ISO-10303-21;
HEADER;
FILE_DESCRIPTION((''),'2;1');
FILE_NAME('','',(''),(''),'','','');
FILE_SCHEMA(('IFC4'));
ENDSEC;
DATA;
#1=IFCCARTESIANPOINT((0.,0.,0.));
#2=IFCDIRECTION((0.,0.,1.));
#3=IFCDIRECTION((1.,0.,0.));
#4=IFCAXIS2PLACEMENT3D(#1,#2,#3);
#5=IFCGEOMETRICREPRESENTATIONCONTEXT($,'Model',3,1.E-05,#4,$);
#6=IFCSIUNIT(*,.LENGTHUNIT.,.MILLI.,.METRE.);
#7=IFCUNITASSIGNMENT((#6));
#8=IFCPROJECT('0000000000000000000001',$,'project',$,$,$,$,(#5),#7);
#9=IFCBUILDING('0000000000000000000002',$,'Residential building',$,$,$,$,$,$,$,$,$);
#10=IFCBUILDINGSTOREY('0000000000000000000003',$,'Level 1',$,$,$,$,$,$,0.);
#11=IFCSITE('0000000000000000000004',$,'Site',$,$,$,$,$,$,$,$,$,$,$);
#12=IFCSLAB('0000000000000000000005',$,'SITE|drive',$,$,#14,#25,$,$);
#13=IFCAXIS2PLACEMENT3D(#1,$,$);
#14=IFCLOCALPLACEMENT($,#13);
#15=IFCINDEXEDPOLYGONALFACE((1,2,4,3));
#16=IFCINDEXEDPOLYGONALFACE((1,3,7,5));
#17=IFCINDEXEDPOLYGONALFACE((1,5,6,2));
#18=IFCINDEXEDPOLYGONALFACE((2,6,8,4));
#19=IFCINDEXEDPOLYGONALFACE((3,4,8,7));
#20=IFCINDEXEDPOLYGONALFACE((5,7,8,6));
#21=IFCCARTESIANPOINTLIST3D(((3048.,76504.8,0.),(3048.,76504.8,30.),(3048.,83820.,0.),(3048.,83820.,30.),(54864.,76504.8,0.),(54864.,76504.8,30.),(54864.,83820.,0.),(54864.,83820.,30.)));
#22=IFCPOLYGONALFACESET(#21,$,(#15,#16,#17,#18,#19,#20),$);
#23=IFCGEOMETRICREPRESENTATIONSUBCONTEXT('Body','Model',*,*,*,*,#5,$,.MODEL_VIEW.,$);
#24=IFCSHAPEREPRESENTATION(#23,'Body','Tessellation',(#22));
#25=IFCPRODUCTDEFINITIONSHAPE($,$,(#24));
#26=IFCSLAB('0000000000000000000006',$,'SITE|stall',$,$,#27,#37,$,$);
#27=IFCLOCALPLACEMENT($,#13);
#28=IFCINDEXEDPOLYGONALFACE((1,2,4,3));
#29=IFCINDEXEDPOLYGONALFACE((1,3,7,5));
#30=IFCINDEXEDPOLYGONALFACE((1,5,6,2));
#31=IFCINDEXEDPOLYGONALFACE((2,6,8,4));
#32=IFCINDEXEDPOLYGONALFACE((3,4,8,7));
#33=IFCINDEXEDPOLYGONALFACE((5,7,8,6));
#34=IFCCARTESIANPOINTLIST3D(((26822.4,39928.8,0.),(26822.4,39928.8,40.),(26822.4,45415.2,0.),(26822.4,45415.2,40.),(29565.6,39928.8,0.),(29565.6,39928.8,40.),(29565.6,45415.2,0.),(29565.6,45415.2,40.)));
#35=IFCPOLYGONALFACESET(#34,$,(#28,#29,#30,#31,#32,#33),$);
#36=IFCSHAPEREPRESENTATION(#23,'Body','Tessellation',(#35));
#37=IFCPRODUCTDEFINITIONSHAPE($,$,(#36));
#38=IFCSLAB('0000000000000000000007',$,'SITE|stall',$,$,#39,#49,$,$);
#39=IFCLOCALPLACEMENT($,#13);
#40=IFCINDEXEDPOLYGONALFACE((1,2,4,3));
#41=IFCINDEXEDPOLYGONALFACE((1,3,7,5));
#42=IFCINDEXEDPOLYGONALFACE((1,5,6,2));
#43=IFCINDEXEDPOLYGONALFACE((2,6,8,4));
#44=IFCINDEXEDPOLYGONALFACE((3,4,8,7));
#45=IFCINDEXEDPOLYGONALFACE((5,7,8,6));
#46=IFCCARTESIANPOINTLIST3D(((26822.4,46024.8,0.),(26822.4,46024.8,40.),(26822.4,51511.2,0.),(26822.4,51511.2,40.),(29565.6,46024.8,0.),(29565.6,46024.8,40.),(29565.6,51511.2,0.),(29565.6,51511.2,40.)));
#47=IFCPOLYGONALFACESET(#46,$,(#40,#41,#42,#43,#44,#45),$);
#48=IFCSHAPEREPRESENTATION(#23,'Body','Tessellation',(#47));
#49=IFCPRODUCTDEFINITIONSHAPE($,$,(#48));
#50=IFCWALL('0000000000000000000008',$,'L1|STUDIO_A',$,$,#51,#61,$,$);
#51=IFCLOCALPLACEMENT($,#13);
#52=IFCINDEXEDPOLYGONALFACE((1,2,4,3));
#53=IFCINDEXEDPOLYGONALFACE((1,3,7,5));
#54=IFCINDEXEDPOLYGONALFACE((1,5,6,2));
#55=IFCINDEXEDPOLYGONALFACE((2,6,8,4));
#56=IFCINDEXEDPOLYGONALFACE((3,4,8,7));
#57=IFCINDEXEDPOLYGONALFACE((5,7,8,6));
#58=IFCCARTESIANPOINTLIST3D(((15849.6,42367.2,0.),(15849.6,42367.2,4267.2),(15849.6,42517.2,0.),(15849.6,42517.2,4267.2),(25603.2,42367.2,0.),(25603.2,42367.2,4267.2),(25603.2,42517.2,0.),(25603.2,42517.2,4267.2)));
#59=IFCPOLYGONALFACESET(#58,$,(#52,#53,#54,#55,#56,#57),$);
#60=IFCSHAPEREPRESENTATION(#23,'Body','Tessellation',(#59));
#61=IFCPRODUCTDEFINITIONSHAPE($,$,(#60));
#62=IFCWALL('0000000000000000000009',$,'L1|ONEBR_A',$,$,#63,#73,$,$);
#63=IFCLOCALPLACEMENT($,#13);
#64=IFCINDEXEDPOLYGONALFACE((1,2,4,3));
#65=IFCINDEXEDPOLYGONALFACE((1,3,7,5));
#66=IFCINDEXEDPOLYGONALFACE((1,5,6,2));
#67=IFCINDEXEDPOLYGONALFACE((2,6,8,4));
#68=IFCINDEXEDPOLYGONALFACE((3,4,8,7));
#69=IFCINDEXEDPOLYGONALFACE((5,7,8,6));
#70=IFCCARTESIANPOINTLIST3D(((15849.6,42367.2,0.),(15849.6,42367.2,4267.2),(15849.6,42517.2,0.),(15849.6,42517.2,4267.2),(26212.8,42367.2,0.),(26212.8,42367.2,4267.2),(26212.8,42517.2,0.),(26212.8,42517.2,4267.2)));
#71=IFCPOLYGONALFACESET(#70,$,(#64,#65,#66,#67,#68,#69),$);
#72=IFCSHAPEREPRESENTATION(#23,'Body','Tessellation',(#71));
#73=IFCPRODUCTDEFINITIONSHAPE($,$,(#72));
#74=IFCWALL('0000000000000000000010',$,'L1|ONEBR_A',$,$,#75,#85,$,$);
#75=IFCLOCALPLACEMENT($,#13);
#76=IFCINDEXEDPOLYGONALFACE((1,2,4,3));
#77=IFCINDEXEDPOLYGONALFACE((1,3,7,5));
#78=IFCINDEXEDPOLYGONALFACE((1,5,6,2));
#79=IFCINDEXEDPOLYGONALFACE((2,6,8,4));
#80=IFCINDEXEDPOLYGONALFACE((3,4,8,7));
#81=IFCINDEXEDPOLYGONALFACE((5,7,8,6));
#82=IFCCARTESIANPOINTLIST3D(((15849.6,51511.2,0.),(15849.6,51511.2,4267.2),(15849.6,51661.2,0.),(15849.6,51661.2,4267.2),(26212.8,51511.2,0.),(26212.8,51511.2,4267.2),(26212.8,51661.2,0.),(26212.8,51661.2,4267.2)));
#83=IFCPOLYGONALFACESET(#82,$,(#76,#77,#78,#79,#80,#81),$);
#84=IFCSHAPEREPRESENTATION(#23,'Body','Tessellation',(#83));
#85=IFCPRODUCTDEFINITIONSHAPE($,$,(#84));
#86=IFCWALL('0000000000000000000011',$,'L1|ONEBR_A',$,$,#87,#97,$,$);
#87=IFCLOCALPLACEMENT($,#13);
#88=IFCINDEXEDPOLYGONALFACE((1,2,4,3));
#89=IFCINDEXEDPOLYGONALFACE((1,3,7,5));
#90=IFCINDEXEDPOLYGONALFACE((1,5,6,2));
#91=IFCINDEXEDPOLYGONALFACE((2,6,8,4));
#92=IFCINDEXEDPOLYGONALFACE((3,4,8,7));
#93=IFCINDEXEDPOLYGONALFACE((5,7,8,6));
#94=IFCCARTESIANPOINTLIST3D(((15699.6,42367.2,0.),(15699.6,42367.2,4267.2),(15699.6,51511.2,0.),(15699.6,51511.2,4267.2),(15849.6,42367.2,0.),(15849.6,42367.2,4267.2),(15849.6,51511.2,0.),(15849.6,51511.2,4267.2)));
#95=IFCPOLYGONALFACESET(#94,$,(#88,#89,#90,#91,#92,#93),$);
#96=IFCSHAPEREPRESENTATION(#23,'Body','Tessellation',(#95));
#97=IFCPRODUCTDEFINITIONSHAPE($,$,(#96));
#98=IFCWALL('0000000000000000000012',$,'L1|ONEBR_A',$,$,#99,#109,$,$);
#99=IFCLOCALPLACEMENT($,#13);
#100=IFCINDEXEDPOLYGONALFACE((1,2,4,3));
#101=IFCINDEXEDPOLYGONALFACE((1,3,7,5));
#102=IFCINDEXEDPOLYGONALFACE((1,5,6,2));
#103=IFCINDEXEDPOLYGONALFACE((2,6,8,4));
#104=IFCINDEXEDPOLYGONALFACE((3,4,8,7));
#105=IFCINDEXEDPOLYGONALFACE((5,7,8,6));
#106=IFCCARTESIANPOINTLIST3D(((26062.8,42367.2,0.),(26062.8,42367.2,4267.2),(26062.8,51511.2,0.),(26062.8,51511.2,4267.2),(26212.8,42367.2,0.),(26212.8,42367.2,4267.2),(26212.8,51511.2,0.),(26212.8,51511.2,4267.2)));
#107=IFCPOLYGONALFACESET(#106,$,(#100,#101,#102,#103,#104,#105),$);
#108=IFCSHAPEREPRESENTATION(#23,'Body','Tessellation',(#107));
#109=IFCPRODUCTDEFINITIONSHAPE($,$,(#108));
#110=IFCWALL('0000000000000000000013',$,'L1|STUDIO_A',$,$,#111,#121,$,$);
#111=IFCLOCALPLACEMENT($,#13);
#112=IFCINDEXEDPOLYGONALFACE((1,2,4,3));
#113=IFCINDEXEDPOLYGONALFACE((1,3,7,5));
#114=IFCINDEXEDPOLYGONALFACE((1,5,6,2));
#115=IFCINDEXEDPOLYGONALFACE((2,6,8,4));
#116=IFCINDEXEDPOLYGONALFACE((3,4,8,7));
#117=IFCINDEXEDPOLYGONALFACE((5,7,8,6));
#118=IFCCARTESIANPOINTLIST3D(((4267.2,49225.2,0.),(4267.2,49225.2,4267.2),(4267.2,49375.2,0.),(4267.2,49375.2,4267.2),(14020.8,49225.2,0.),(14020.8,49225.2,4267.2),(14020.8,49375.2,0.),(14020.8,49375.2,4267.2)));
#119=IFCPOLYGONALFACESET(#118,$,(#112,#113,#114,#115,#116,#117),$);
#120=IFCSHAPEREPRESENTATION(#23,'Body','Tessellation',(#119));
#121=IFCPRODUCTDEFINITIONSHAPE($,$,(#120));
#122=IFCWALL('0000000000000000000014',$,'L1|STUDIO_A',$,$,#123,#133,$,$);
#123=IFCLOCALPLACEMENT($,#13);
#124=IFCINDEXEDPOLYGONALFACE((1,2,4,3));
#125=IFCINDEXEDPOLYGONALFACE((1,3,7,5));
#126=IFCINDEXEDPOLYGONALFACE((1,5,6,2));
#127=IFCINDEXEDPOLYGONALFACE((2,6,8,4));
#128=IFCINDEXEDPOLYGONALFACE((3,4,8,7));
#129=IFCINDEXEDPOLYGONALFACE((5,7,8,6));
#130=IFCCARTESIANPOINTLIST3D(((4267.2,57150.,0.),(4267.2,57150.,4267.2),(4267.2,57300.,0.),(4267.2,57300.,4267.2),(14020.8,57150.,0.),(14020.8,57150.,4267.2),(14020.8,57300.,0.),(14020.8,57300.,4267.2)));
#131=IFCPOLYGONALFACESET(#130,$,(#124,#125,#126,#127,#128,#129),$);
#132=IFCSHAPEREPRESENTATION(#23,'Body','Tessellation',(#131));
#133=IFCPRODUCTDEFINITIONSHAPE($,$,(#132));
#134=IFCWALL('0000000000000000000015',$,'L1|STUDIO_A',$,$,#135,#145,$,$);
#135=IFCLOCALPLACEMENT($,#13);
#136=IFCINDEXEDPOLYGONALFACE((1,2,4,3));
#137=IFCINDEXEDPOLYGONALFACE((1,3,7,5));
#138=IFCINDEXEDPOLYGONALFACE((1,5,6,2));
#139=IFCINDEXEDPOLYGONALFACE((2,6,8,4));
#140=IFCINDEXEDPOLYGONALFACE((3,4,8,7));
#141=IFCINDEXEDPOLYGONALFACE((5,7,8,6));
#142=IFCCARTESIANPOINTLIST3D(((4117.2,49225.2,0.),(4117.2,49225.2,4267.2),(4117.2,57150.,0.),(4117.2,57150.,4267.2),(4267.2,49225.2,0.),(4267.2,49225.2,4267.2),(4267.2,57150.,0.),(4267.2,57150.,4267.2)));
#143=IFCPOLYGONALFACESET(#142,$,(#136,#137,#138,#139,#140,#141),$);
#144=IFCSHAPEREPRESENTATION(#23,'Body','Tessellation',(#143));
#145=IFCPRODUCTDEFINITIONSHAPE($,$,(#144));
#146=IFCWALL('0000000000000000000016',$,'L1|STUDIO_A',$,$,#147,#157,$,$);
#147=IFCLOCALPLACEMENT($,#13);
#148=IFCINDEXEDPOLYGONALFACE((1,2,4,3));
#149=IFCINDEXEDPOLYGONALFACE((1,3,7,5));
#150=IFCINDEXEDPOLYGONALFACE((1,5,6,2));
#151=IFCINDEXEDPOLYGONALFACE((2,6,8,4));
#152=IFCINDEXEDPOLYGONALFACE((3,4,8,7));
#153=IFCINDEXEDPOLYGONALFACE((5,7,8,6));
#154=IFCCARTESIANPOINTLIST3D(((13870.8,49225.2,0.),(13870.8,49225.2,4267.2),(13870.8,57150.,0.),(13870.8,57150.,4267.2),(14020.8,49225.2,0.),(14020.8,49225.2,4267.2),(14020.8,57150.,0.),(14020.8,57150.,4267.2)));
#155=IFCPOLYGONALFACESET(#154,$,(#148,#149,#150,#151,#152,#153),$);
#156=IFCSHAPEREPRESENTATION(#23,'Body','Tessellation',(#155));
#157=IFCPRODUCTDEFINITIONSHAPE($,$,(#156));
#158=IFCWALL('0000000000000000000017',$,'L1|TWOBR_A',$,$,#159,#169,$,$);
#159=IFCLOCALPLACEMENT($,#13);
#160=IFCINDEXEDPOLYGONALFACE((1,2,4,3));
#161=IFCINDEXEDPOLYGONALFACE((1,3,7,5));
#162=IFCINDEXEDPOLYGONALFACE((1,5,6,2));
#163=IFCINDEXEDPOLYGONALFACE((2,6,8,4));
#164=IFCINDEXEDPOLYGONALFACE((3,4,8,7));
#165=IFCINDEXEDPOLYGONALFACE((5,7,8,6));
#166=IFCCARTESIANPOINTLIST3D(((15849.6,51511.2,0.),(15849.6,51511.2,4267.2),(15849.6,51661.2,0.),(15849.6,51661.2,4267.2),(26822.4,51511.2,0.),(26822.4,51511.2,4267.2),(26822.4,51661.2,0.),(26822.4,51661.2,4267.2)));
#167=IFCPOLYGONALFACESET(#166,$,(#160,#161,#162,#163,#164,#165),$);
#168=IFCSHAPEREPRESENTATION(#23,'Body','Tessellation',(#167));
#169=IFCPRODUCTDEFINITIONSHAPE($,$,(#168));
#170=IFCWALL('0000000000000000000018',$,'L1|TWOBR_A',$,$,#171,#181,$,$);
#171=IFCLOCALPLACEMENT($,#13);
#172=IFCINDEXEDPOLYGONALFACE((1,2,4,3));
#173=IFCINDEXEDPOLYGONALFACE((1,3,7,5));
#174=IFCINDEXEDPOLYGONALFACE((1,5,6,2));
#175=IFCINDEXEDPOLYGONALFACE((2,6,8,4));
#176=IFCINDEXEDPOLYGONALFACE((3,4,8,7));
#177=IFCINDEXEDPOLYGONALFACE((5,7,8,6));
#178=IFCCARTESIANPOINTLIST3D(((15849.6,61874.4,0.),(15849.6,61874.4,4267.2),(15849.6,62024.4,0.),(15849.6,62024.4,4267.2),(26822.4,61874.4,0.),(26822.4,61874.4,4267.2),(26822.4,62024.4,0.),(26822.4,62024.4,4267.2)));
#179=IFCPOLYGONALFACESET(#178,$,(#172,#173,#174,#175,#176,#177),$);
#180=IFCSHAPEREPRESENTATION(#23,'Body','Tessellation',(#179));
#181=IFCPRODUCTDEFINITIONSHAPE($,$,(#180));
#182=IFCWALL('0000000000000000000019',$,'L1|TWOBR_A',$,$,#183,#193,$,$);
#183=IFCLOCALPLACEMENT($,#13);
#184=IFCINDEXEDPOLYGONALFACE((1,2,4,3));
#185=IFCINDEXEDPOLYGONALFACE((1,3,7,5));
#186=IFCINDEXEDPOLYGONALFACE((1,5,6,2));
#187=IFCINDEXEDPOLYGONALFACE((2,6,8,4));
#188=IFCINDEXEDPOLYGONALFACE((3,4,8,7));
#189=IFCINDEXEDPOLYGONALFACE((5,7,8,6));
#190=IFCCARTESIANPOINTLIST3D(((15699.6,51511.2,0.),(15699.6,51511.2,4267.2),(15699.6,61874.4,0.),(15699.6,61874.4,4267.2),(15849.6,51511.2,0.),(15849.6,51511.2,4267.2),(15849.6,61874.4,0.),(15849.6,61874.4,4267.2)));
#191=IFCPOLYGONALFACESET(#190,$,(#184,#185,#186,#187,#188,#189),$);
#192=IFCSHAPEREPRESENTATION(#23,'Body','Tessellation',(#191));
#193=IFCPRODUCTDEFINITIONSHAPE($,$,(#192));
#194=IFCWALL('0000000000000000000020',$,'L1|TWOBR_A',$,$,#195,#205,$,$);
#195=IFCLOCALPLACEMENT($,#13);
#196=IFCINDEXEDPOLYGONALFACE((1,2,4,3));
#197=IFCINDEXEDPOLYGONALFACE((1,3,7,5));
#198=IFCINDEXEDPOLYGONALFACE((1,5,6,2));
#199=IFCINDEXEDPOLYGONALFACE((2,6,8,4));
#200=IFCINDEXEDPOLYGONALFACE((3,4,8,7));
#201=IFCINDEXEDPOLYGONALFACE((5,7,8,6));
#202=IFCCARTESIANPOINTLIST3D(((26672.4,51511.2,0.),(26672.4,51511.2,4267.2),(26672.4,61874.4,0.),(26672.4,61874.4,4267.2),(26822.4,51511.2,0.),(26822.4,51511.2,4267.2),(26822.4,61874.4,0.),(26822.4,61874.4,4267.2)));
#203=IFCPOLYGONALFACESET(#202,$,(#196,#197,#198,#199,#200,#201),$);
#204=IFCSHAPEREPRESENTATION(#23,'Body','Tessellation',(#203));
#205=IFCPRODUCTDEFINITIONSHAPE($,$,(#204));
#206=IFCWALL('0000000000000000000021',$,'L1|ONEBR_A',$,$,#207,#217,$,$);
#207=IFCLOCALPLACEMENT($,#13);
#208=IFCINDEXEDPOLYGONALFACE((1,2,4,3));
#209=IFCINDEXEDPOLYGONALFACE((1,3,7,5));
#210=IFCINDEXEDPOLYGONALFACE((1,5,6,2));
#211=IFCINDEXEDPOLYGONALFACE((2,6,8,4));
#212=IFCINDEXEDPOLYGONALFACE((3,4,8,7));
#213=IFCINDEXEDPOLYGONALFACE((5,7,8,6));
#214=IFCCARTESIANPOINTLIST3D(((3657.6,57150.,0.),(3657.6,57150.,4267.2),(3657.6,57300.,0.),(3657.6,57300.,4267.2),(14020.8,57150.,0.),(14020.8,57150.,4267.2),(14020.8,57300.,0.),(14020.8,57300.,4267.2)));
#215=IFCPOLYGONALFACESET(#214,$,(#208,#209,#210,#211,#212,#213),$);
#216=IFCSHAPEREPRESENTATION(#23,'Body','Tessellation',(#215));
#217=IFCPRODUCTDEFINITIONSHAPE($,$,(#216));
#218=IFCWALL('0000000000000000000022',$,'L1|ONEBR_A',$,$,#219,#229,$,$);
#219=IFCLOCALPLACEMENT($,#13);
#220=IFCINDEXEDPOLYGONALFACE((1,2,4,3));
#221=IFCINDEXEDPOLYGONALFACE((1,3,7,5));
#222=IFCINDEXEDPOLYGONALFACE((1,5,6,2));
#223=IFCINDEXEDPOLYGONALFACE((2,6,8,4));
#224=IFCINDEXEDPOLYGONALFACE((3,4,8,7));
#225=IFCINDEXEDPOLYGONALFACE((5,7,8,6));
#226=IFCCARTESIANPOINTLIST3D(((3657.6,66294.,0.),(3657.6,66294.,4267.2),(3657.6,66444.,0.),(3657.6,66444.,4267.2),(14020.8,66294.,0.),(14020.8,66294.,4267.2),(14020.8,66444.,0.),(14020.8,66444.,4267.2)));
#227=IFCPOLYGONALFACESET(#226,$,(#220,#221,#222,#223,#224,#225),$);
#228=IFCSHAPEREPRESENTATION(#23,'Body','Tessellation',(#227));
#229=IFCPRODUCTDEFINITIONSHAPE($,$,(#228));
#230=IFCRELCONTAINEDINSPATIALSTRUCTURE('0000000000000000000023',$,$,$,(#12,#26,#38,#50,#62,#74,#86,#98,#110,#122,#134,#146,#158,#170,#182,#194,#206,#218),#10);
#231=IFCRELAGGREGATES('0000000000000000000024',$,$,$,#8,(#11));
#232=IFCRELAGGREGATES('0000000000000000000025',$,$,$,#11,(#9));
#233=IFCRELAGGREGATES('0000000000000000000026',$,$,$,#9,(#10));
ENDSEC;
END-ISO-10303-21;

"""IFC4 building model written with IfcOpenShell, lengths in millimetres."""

from ifc_helpers import new_model, si_unit, frame, origin_with_axes, place, context, subcontext, project, spatial, indexed_curve, outline, extrude, element, save


model = new_model("IFC4")

# Units and contexts
model_context = context("Model", 3, precision=1e-05, world=origin_with_axes())
body_context = subcontext(model_context, "Body", "Model", "MODEL_VIEW")
ifc_project = project(units=[si_unit("LENGTHUNIT", "METRE", prefix="MILLI")], contexts=[model_context])

# Site, building, storey
site = spatial("IfcSite", under=ifc_project, Name="Site")
building = spatial("IfcBuilding", under=site, Name="Residential building")
storey = spatial("IfcBuildingStorey", under=building, Name="Level 1", Elevation=0.0)

# Slabs
slab_placement = place(None, frame((3048.0, 76504.8, 0.0), z_axis=(0.0, 0.0, 1.0), x_axis=(1.0, 0.0, 0.0)))
element("IfcSlab", 1, at=slab_placement, inside=storey, Name="SITE|drive", context=body_context, shape_type="SweptSolid", body=[
    extrude(outline(indexed_curve([(0.0, 0.0), (51816.0, 0.0), (51816.0, 7315.2), (0.0, 7315.2), (0.0, 0.0)])), None, (0.0, 0.0, 1.0), 30.0),
])
for number, where, z_axis, x_axis, name in (
    (2, (26822.4, 39928.8, 0.0), (0.0, 0.0, 1.0), (1.0, 0.0, 0.0), "SITE|stall"),
    (3, (26822.4, 46024.8, 0.0), (0.0, 0.0, 1.0), (1.0, 0.0, 0.0), "SITE|stall"),
):
    element("IfcSlab", number, at=place(None, frame(where, z_axis=z_axis, x_axis=x_axis)), inside=storey, Name=name, context=body_context, shape_type="SweptSolid", body=[
        extrude(outline(indexed_curve([(0.0, 0.0), (2743.2, 0.0), (2743.2, 5486.4), (0.0, 5486.4), (0.0, 0.0)])), None, (0.0, 0.0, 1.0), 40.0),
    ])

# Walls
wall_placement = place(None, frame((15849.6, 42367.2, 0.0), z_axis=(0.0, 0.0, 1.0), x_axis=(1.0, 0.0, 0.0)))
element("IfcWall", 4, at=wall_placement, inside=storey, Name="L1|STUDIO_A", context=body_context, shape_type="SweptSolid", body=[
    extrude(outline(indexed_curve([(0.0, 0.0), (0.0, 150.0), (9753.6, 150.0), (9753.6, 0.0), (0.0, 0.0)], self_intersect=False)), origin_with_axes(), (0.0, 0.0, 1.0), 4267.2),
])
for number, where, z_axis, x_axis, name in (
    (5, (15849.6, 42367.2, 0.0), (0.0, 0.0, 1.0), (1.0, 0.0, 0.0), "L1|ONEBR_A"),
    (6, (15849.6, 51511.2, 0.0), (0.0, 0.0, 1.0), (1.0, 0.0, 0.0), "L1|ONEBR_A"),
):
    element("IfcWall", number, at=place(None, frame(where, z_axis=z_axis, x_axis=x_axis)), inside=storey, Name=name, context=body_context, shape_type="SweptSolid", body=[
        extrude(outline(indexed_curve([(0.0, 0.0), (0.0, 150.0), (10363.2, 150.0), (10363.2, 0.0), (0.0, 0.0)], self_intersect=False)), origin_with_axes(), (0.0, 0.0, 1.0), 4267.2),
    ])
for number, where, z_axis, x_axis, name in (
    (7, (15849.6, 42367.2, 0.0), (0.0, 0.0, 1.0), (0.0, 1.0, 0.0), "L1|ONEBR_A"),
    (8, (26212.8, 42367.2, 0.0), (0.0, 0.0, 1.0), (0.0, 1.0, 0.0), "L1|ONEBR_A"),
):
    element("IfcWall", number, at=place(None, frame(where, z_axis=z_axis, x_axis=x_axis)), inside=storey, Name=name, context=body_context, shape_type="SweptSolid", body=[
        extrude(outline(indexed_curve([(0.0, 0.0), (0.0, 150.0), (9144.0, 150.0), (9144.0, 0.0), (0.0, 0.0)], self_intersect=False)), origin_with_axes(), (0.0, 0.0, 1.0), 4267.2),
    ])
for number, where, z_axis, x_axis, name in (
    (9, (4267.2, 49225.2, 0.0), (0.0, 0.0, 1.0), (1.0, 0.0, 0.0), "L1|STUDIO_A"),
    (10, (4267.2, 57150.0, 0.0), (0.0, 0.0, 1.0), (1.0, 0.0, 0.0), "L1|STUDIO_A"),
):
    element("IfcWall", number, at=place(None, frame(where, z_axis=z_axis, x_axis=x_axis)), inside=storey, Name=name, context=body_context, shape_type="SweptSolid", body=[
        extrude(outline(indexed_curve([(0.0, 0.0), (0.0, 150.0), (9753.6, 150.0), (9753.6, 0.0), (0.0, 0.0)], self_intersect=False)), origin_with_axes(), (0.0, 0.0, 1.0), 4267.2),
    ])
for number, where, z_axis, x_axis, name in (
    (11, (4267.2, 49225.2, 0.0), (0.0, 0.0, 1.0), (0.0, 1.0, 0.0), "L1|STUDIO_A"),
    (12, (14020.8, 49225.2, 0.0), (0.0, 0.0, 1.0), (0.0, 1.0, 0.0), "L1|STUDIO_A"),
):
    element("IfcWall", number, at=place(None, frame(where, z_axis=z_axis, x_axis=x_axis)), inside=storey, Name=name, context=body_context, shape_type="SweptSolid", body=[
        extrude(outline(indexed_curve([(0.0, 0.0), (0.0, 150.0), (7924.8, 150.0), (7924.8, 0.0), (0.0, 0.0)], self_intersect=False)), origin_with_axes(), (0.0, 0.0, 1.0), 4267.2),
    ])
for number, where, z_axis, x_axis, name in (
    (13, (15849.6, 51511.2, 0.0), (0.0, 0.0, 1.0), (1.0, 0.0, 0.0), "L1|TWOBR_A"),
    (14, (15849.6, 61874.4, 0.0), (0.0, 0.0, 1.0), (1.0, 0.0, 0.0), "L1|TWOBR_A"),
):
    element("IfcWall", number, at=place(None, frame(where, z_axis=z_axis, x_axis=x_axis)), inside=storey, Name=name, context=body_context, shape_type="SweptSolid", body=[
        extrude(outline(indexed_curve([(0.0, 0.0), (0.0, 150.0), (10972.8, 150.0), (10972.8, 0.0), (0.0, 0.0)], self_intersect=False)), origin_with_axes(), (0.0, 0.0, 1.0), 4267.2),
    ])
for number, where, z_axis, x_axis, name in (
    (15, (15849.6, 51511.2, 0.0), (0.0, 0.0, 1.0), (0.0, 1.0, 0.0), "L1|TWOBR_A"),
    (16, (26822.4, 51511.2, 0.0), (0.0, 0.0, 1.0), (0.0, 1.0, 0.0), "L1|TWOBR_A"),
    (17, (3657.6, 57150.0, 0.0), (0.0, 0.0, 1.0), (1.0, 0.0, 0.0), "L1|ONEBR_A"),
    (18, (3657.6, 66294.0, 0.0), (0.0, 0.0, 1.0), (1.0, 0.0, 0.0), "L1|ONEBR_A"),
):
    element("IfcWall", number, at=place(None, frame(where, z_axis=z_axis, x_axis=x_axis)), inside=storey, Name=name, context=body_context, shape_type="SweptSolid", body=[
        extrude(outline(indexed_curve([(0.0, 0.0), (0.0, 150.0), (10363.2, 150.0), (10363.2, 0.0), (0.0, 0.0)], self_intersect=False)), origin_with_axes(), (0.0, 0.0, 1.0), 4267.2),
    ])

save(model, "model.ifc")
